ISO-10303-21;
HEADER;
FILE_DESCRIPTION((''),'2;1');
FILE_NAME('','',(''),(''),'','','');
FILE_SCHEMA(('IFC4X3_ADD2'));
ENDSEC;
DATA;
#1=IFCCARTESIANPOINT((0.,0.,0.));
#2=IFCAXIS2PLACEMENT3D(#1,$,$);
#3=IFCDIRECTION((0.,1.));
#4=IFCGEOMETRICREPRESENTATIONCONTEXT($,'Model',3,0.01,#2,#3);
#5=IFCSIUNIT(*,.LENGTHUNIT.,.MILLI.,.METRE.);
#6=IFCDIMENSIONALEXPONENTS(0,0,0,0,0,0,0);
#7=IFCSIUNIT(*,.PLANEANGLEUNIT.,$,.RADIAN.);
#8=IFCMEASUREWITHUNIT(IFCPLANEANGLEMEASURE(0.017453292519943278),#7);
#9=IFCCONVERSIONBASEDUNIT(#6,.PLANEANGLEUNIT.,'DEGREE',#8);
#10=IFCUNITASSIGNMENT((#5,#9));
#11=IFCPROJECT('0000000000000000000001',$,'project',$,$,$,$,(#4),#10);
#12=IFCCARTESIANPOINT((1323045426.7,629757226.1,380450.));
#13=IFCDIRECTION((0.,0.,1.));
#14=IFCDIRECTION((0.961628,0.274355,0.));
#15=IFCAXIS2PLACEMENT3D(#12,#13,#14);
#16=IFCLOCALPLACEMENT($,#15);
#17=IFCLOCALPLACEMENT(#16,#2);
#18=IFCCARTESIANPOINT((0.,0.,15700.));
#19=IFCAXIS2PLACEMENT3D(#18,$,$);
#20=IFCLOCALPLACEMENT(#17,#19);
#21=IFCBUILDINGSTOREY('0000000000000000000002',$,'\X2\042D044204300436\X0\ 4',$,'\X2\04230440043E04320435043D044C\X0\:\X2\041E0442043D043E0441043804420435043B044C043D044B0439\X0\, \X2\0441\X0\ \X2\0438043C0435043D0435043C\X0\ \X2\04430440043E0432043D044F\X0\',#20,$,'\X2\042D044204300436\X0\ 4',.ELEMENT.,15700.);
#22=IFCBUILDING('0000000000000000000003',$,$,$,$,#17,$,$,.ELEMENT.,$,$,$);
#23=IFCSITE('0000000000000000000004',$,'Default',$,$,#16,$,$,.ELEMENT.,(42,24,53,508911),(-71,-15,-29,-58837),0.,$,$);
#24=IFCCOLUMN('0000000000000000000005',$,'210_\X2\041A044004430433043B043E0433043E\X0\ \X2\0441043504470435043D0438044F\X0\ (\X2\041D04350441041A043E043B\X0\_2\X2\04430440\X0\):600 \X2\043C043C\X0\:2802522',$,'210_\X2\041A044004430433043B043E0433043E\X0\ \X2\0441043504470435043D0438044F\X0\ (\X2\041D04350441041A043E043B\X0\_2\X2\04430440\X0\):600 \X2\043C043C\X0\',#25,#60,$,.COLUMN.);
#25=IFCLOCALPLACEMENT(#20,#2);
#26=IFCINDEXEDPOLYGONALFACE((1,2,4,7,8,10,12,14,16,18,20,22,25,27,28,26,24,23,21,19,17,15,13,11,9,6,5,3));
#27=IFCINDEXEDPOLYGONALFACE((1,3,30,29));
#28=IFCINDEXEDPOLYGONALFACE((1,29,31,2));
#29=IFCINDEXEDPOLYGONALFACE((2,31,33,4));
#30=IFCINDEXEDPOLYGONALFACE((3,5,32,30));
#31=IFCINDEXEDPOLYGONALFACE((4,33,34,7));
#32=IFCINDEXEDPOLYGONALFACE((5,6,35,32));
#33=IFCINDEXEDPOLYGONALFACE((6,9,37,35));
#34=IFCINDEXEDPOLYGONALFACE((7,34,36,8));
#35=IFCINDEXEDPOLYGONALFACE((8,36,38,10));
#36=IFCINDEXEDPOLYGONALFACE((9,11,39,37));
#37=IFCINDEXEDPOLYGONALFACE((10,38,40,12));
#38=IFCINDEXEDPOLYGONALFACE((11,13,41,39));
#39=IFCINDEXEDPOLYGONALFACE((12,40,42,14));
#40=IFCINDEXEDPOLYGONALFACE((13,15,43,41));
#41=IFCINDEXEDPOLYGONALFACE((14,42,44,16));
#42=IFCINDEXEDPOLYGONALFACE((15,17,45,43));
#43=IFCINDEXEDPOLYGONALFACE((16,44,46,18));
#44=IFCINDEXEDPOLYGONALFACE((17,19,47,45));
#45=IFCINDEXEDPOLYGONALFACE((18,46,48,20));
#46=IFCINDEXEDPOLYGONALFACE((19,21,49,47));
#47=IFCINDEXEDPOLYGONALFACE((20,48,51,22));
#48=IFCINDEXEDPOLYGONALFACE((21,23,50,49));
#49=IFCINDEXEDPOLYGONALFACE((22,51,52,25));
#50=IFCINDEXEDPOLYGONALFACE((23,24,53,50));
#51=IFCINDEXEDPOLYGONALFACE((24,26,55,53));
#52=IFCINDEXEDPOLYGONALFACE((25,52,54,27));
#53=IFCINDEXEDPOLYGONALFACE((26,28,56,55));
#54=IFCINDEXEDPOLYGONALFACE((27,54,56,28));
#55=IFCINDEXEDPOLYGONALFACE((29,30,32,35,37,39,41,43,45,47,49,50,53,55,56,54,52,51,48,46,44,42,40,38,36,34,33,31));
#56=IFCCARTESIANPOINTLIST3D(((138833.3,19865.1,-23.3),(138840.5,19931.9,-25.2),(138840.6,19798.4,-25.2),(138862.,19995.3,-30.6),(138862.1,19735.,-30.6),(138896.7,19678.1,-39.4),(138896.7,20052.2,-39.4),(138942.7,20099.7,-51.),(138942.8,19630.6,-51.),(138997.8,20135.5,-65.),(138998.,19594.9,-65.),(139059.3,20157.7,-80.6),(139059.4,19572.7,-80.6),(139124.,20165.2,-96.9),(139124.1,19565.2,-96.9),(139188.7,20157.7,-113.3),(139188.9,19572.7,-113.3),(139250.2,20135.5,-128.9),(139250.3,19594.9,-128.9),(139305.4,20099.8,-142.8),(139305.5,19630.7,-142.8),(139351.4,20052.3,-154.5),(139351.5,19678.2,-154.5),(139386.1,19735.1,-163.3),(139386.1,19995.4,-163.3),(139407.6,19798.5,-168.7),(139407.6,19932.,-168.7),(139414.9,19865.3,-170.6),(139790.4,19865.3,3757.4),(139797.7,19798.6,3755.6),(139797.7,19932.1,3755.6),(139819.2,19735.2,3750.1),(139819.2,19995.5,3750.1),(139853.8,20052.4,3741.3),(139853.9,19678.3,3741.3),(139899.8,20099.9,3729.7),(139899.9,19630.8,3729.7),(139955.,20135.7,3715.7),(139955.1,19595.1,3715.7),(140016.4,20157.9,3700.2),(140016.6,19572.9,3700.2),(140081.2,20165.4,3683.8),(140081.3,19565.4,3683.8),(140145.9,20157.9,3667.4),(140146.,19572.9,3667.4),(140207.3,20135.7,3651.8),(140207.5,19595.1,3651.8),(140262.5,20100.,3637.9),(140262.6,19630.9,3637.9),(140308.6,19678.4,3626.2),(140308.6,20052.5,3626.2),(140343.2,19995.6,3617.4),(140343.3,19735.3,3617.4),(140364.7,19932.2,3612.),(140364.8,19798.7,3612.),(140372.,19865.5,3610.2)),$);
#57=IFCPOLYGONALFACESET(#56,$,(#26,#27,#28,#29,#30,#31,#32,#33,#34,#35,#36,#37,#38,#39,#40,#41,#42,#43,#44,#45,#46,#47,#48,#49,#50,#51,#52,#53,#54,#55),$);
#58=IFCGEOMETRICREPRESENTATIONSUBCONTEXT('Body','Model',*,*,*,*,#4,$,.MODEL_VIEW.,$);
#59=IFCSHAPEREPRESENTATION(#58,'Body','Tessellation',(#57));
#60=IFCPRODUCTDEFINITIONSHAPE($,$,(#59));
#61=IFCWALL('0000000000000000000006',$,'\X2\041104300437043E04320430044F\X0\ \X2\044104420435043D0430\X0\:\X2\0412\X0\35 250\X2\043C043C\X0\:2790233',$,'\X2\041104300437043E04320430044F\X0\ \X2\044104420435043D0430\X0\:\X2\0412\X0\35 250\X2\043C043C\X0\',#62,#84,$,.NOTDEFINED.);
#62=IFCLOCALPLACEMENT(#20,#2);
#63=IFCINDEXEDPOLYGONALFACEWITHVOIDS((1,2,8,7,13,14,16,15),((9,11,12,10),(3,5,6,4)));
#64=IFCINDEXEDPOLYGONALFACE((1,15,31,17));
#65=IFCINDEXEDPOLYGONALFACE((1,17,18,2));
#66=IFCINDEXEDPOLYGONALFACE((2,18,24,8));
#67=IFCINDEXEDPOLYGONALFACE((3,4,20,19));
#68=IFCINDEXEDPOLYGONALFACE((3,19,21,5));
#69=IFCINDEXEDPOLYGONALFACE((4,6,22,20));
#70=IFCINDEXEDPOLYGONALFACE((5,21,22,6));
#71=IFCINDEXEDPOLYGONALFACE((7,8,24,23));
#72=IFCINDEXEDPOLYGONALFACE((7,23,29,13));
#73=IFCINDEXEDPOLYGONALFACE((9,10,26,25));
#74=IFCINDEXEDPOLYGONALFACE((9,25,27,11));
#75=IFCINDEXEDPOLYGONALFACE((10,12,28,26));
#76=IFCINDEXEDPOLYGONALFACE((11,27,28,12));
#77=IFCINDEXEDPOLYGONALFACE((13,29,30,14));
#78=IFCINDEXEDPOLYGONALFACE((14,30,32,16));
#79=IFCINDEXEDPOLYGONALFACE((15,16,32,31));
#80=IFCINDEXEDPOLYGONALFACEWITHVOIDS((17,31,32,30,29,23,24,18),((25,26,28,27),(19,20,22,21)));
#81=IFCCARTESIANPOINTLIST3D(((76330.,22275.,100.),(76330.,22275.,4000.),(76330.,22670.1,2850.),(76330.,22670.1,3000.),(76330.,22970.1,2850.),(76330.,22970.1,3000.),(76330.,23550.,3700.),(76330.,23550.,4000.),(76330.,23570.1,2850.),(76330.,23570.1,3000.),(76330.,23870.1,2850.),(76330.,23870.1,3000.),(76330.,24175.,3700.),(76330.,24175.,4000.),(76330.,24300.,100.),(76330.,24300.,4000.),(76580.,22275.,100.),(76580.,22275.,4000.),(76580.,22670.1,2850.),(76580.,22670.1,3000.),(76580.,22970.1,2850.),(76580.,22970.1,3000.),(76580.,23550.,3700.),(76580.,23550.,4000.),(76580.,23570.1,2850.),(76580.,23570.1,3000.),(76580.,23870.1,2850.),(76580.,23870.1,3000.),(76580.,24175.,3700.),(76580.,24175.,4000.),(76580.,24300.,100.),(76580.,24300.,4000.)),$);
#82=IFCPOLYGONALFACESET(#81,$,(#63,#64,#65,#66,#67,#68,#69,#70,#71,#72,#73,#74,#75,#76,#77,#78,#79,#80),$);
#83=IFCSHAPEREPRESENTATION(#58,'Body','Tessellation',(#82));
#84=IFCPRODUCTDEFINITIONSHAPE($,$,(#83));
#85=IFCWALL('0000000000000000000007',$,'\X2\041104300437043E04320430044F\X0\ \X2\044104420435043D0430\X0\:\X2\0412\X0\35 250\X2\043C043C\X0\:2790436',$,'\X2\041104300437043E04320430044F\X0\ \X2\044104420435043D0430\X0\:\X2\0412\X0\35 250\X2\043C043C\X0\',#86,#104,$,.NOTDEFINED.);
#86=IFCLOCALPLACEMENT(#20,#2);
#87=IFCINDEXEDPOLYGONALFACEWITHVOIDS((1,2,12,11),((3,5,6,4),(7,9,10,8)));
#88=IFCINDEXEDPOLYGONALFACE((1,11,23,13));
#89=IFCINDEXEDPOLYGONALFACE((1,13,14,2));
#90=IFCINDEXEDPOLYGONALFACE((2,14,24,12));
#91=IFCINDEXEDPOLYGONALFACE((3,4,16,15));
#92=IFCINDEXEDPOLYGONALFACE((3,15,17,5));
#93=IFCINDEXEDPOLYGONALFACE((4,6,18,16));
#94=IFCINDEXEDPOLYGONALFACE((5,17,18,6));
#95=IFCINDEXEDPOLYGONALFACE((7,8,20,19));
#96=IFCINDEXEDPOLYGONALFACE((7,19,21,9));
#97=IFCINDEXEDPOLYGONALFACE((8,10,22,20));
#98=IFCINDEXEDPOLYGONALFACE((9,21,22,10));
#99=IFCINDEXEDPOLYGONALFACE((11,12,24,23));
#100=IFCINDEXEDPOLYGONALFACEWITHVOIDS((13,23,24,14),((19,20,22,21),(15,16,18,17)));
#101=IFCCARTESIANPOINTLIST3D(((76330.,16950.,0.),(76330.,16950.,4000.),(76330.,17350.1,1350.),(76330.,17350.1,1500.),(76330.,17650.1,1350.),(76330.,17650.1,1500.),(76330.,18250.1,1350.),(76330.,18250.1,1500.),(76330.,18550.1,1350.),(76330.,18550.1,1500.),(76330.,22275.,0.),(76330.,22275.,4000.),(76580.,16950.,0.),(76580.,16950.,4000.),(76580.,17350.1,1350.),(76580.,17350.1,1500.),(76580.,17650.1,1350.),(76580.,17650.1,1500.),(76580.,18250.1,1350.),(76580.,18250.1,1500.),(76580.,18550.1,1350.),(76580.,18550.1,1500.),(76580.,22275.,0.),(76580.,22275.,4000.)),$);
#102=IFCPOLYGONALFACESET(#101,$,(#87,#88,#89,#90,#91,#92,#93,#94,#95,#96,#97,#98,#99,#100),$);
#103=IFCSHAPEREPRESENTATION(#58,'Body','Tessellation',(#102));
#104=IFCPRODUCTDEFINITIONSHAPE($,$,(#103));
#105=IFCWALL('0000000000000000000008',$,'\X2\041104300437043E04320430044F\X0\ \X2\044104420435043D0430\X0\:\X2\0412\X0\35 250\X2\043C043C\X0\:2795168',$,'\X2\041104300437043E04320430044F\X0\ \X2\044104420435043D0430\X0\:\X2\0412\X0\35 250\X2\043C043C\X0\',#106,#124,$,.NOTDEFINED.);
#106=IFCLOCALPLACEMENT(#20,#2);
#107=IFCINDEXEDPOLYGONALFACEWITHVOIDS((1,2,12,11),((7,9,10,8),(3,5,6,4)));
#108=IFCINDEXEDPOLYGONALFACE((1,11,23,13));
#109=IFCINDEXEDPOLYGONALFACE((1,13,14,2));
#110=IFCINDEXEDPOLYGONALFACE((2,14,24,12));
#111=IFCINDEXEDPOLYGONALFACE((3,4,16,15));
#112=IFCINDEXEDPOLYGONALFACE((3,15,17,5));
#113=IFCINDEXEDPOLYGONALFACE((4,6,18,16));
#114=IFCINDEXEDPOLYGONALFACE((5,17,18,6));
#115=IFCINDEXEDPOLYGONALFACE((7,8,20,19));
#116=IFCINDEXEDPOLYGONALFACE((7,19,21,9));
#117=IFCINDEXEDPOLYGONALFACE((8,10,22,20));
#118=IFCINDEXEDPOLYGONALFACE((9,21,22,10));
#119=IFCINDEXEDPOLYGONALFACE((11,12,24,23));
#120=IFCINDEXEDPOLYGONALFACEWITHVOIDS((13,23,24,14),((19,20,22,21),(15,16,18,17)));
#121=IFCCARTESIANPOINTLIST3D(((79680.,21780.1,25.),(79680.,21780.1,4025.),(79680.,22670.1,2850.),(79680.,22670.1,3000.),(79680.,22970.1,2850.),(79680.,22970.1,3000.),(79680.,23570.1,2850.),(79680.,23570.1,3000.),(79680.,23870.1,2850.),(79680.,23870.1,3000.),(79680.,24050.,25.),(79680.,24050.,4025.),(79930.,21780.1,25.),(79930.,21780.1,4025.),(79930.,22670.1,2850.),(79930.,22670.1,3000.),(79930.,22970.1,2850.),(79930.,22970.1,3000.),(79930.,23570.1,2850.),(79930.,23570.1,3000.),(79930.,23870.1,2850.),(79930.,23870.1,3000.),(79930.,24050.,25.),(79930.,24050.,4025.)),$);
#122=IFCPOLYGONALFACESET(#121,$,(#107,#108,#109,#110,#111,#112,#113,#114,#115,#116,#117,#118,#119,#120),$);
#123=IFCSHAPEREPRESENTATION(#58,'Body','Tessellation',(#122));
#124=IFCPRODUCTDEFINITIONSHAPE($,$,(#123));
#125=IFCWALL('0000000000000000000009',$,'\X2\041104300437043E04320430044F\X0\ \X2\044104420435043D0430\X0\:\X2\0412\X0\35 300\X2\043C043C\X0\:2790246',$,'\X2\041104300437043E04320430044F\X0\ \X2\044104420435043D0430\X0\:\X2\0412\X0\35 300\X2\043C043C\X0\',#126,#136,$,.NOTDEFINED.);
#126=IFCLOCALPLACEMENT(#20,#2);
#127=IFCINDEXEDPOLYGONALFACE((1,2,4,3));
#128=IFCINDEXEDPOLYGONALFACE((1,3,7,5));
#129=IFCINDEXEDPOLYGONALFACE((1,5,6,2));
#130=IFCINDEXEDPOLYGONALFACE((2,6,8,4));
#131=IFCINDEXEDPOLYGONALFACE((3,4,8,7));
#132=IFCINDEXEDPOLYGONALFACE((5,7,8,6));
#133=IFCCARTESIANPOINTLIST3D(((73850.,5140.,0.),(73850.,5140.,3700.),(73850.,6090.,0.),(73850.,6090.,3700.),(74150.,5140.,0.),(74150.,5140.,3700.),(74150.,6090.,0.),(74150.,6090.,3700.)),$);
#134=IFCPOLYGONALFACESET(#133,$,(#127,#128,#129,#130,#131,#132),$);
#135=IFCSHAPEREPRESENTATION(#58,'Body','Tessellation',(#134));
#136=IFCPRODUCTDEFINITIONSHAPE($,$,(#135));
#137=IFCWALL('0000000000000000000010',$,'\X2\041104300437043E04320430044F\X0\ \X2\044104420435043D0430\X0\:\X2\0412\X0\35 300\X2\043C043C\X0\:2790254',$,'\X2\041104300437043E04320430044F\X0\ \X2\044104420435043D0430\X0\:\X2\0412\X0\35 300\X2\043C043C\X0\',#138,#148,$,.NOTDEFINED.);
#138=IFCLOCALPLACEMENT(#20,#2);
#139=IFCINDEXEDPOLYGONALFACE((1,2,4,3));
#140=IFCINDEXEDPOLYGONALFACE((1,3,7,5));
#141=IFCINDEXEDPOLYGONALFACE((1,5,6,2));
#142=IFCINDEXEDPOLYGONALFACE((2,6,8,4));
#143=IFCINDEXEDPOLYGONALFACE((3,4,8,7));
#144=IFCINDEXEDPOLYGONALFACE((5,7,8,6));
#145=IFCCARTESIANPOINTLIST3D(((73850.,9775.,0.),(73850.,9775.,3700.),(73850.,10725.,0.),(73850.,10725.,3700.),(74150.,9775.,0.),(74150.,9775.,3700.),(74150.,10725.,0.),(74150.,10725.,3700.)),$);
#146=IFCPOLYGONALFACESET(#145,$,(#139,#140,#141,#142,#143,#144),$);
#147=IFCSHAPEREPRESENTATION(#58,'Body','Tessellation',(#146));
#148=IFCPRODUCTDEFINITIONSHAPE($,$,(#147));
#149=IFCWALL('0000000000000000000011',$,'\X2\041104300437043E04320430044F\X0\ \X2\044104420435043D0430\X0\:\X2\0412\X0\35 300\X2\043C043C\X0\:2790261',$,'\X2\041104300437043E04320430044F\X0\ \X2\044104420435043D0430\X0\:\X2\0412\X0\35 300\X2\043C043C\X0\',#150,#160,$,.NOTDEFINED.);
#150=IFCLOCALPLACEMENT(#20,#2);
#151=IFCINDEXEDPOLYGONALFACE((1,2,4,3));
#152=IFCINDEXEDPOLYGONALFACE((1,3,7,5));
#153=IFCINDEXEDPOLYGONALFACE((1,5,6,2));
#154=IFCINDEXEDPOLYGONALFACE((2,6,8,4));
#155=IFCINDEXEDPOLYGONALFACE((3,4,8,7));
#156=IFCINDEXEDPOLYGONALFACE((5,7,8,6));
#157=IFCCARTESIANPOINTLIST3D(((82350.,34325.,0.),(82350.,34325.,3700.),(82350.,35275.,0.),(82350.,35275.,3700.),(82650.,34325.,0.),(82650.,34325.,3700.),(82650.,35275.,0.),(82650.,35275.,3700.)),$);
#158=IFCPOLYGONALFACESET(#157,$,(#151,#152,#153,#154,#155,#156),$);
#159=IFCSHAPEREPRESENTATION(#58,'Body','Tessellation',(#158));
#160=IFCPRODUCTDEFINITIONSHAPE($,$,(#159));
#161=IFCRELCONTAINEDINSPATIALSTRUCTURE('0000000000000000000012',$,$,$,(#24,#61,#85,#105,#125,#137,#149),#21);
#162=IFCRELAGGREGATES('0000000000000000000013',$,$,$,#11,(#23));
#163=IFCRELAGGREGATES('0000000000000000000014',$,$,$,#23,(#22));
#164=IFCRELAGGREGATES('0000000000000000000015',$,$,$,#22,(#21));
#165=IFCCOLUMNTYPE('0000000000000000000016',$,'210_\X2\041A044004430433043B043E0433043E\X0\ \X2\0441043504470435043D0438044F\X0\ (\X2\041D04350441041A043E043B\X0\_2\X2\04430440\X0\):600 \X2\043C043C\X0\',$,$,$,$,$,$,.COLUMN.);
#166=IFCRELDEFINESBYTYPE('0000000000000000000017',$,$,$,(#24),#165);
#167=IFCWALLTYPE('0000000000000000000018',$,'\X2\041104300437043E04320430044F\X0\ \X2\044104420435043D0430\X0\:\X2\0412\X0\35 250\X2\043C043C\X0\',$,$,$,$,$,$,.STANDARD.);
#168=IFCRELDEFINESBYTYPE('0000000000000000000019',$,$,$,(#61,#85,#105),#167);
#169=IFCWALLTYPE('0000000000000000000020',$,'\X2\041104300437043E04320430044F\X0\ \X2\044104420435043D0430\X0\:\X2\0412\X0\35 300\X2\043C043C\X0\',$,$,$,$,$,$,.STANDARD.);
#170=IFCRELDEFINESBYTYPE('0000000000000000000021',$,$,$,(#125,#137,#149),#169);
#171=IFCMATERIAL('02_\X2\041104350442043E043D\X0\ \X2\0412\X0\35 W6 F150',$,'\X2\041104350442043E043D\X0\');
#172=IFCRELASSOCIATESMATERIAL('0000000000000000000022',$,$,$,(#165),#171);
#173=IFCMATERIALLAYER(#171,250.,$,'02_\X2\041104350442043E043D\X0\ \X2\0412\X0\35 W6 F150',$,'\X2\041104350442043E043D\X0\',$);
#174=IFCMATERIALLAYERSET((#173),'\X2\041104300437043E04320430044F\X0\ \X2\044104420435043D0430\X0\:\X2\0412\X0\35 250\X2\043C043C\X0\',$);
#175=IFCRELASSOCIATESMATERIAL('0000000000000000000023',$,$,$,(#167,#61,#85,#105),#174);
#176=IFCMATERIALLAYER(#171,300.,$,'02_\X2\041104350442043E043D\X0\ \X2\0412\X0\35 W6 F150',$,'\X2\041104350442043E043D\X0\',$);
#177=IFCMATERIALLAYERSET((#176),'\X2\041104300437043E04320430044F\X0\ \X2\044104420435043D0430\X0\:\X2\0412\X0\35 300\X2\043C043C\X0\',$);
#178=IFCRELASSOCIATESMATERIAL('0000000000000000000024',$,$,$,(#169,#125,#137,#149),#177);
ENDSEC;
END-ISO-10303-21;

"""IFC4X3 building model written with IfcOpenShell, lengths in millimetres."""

from ifc_helpers import new_model, entity, si_unit, converted_unit, direction, frame, frame_2d, origin, origin_2d_with_axis, place, context, subcontext, project, spatial, rectangle, circle, extrude, source, transform, mapped, material, layer, layer_set, material_profile, profile_set, type_object, type_shapes, element, save


model = new_model("IFC4X3")

# Units and contexts
model_context = context("Model", 3, precision=0.01, world=origin(), true_north=direction((0.0, 1.0)))
body_context = subcontext(model_context, "Body", "Model", "MODEL_VIEW")
ifc_project = project(units=[si_unit("LENGTHUNIT", "METRE", prefix="MILLI"), converted_unit("PLANEANGLEUNIT", "DEGREE", entity("IfcPlaneAngleMeasure", 0.017453292519943278), si_unit("PLANEANGLEUNIT", "RADIAN"), dimensions=[0, 0, 0, 0, 0, 0, 0])], contexts=[model_context])

# Site, building, storey
site_placement = place(None, frame((1323045426.7, 629757226.1, 380450.0), z_axis=(0.0, 0.0, 1.0), x_axis=(0.961628, 0.274355, 0.0)))
site = spatial("IfcSite", under=ifc_project, at=site_placement, Name="Default", CompositionType="ELEMENT", RefLatitude=(42, 24, 53, 508911), RefLongitude=(-71, -15, -29, -58837), RefElevation=0.0)
building_placement = place(site_placement, origin())
building = spatial("IfcBuilding", under=site, at=building_placement, CompositionType="ELEMENT")
storey_placement = place(building_placement, frame((0.0, 0.0, 15700.0)))
storey = spatial("IfcBuildingStorey", under=building, at=storey_placement, Name="Этаж 4", ObjectType="Уровень:Относительный, с именем уровня", LongName="Этаж 4", CompositionType="ELEMENT", Elevation=15700.0)

# Column
ifc_material = material(Name="02_Бетон В35 W6 F150", Category="Бетон")
ifc_material_profile = material_profile(ifc_material, circle(Radius=300.0, at=origin_2d_with_axis()), Name="600 мм")
ifc_profile_set = profile_set([ifc_material_profile], Name="600 мм")
column_type_1 = type_object("IfcColumnType", Name="210_Круглого сечения (НесКол_2ур):600 мм", PredefinedType="COLUMN", material=ifc_profile_set)
shared_shape_1 = source(origin(), body_context, "Body", "SweptSolid", [
    extrude(circle(Radius=300.0, at=frame_2d((0.0, 0.0), x_axis=(1.0, 0.0))), frame((139124.1, 19865.2, 15603.1), z_axis=(0.245422, 0.000054, 0.969416), x_axis=(0.000219, -1.0, 0.0)), (0.0, 0.0, 1.0), 3900.0),
])
type_shapes(column_type_1, [shared_shape_1])
column_1_placement = place(storey_placement, frame((0.0, 0.0, -15700.0)))
element("IfcColumn", 1, at=column_1_placement, inside=storey, type_object=column_type_1, Name="210_Круглого сечения (НесКол_2ур):600 мм:2802522", ObjectType="210_Круглого сечения (НесКол_2ур):600 мм", PredefinedType="COLUMN", context=body_context, shape_type="MappedRepresentation", body=[
    mapped(shared_shape_1, transform((0.0, 0.0, 0.0), scale=1.0)),
])

# Walls, openings
ifc_layer_1 = layer(ifc_material, 250.0, Name="02_Бетон В35 W6 F150", Category="Бетон")
ifc_layer_set_1 = layer_set([ifc_layer_1], Name="Базовая стена:В35 250мм")
wall_type_1 = type_object("IfcWallType", Name="Базовая стена:В35 250мм", PredefinedType="STANDARD", material=ifc_layer_set_1)
wall_1_placement = place(storey_placement, frame((76455.0, 24300.0, 100.0), z_axis=(0.0, 0.0, 1.0), x_axis=(0.0, -1.0, 0.0)))
wall_1 = element("IfcWall", 2, at=wall_1_placement, inside=storey, type_object=wall_type_1, material=ifc_layer_set_1, Name="Базовая стена:В35 250мм:2790233", ObjectType="Базовая стена:В35 250мм", PredefinedType="NOTDEFINED", context=body_context, shape_type="SweptSolid", body=[
    extrude(rectangle(XDim=2025.0, YDim=250.0, at=frame_2d((1012.5, 0.0), x_axis=(-1.0, 0.0))), origin(), (0.0, 0.0, 1.0), 3900.0),
])
opening_1_placement = place(wall_1_placement, origin())
element("IfcOpeningElement", 3, at=opening_1_placement, cuts=wall_1, PredefinedType="OPENING", context=body_context, shape_type="SweptSolid", body=[
    extrude(rectangle(XDim=300.0, YDim=625.0, at=frame_2d((0.0, 0.0), x_axis=(0.0, 1.0))), frame((437.5, 125.0, 3750.0), z_axis=(0.0, -1.0, 0.0), x_axis=(-1.0, 0.0, 0.0)), (0.0, 0.0, 1.0), 250.0),
])
opening_2_placement = place(wall_1_placement, frame((24300.0, -76455.0, 2750.0), z_axis=(0.0, 0.0, 1.0), x_axis=(0.0, 1.0, 0.0)))
element("IfcOpeningElement", 4, at=opening_2_placement, cuts=wall_1, PredefinedType="OPENING", context=body_context, shape_type="SweptSolid", body=[
    extrude(rectangle(XDim=150.0, YDim=300.0, at=frame_2d((0.0, 0.0), x_axis=(0.0, 1.0))), frame((74806.0, 23720.1, 75.0), z_axis=(1.0, 0.0, 0.0), x_axis=(0.0, -1.0, 0.0)), (0.0, 0.0, 1.0), 3048.0),
])
opening_3_placement = place(wall_1_placement, frame((24300.0, -76455.0, 2750.0), z_axis=(0.0, 0.0, 1.0), x_axis=(0.0, 1.0, 0.0)))
element("IfcOpeningElement", 5, at=opening_3_placement, cuts=wall_1, PredefinedType="OPENING", context=body_context, shape_type="SweptSolid", body=[
    extrude(rectangle(XDim=150.0, YDim=300.0, at=frame_2d((0.0, 0.0), x_axis=(0.0, 1.0))), frame((74806.0, 22820.1, 75.0), z_axis=(1.0, 0.0, 0.0), x_axis=(0.0, -1.0, 0.0)), (0.0, 0.0, 1.0), 3048.0),
])
wall_2_placement = place(storey_placement, frame((76455.0, 22275.0, 0.0), z_axis=(0.0, 0.0, 1.0), x_axis=(0.0, -1.0, 0.0)))
wall_2 = element("IfcWall", 6, at=wall_2_placement, inside=storey, type_object=wall_type_1, material=ifc_layer_set_1, Name="Базовая стена:В35 250мм:2790436", ObjectType="Базовая стена:В35 250мм", PredefinedType="NOTDEFINED", context=body_context, shape_type="SweptSolid", body=[
    extrude(rectangle(XDim=5325.0, YDim=250.0, at=frame_2d((2662.5, 0.0), x_axis=(-1.0, 0.0))), origin(), (0.0, 0.0, 1.0), 4000.0),
])
opening_4_placement = place(wall_2_placement, frame((22275.0, -76455.0, 1350.0), z_axis=(0.0, 0.0, 1.0), x_axis=(0.0, 1.0, 0.0)))
element("IfcOpeningElement", 7, at=opening_4_placement, cuts=wall_2, PredefinedType="OPENING", context=body_context, shape_type="SweptSolid", body=[
    extrude(rectangle(XDim=150.0, YDim=300.0, at=frame_2d((0.0, 0.0), x_axis=(0.0, 1.0))), frame((74806.0, 18400.1, 75.0), z_axis=(1.0, 0.0, 0.0), x_axis=(0.0, -1.0, 0.0)), (0.0, 0.0, 1.0), 3048.0),
])
opening_5_placement = place(wall_2_placement, frame((22275.0, -76455.0, 1350.0), z_axis=(0.0, 0.0, 1.0), x_axis=(0.0, 1.0, 0.0)))
element("IfcOpeningElement", 8, at=opening_5_placement, cuts=wall_2, PredefinedType="OPENING", context=body_context, shape_type="SweptSolid", body=[
    extrude(rectangle(XDim=150.0, YDim=300.0, at=frame_2d((0.0, 0.0), x_axis=(0.0, 1.0))), frame((74806.0, 17500.1, 75.0), z_axis=(1.0, 0.0, 0.0), x_axis=(0.0, -1.0, 0.0)), (0.0, 0.0, 1.0), 3048.0),
])
wall_3_placement = place(storey_placement, frame((79805.0, 24050.0, 25.0), z_axis=(0.0, 0.0, 1.0), x_axis=(0.0, -1.0, 0.0)))
wall_3 = element("IfcWall", 9, at=wall_3_placement, inside=storey, type_object=wall_type_1, material=ifc_layer_set_1, Name="Базовая стена:В35 250мм:2795168", ObjectType="Базовая стена:В35 250мм", PredefinedType="NOTDEFINED", context=body_context, shape_type="SweptSolid", body=[
    extrude(rectangle(XDim=2269.9, YDim=250.0, at=frame_2d((1134.9, 0.0), x_axis=(-1.0, 0.0))), origin(), (0.0, 0.0, 1.0), 4000.0),
])
opening_6_placement = place(wall_3_placement, frame((24050.0, -79805.0, 2825.0), z_axis=(0.0, 0.0, 1.0), x_axis=(0.0, 1.0, 0.0)))
element("IfcOpeningElement", 10, at=opening_6_placement, cuts=wall_3, PredefinedType="OPENING", context=body_context, shape_type="SweptSolid", body=[
    extrude(rectangle(XDim=150.0, YDim=300.0, at=frame_2d((0.0, 0.0), x_axis=(0.0, 1.0))), frame((78156.0, 23720.1, 75.0), z_axis=(1.0, 0.0, 0.0), x_axis=(0.0, -1.0, 0.0)), (0.0, 0.0, 1.0), 3048.0),
])
opening_7_placement = place(wall_3_placement, frame((24050.0, -79805.0, 2825.0), z_axis=(0.0, 0.0, 1.0), x_axis=(0.0, 1.0, 0.0)))
element("IfcOpeningElement", 11, at=opening_7_placement, cuts=wall_3, PredefinedType="OPENING", context=body_context, shape_type="SweptSolid", body=[
    extrude(rectangle(XDim=150.0, YDim=300.0, at=frame_2d((0.0, 0.0), x_axis=(0.0, 1.0))), frame((78156.0, 22820.1, 75.0), z_axis=(1.0, 0.0, 0.0), x_axis=(0.0, -1.0, 0.0)), (0.0, 0.0, 1.0), 3048.0),
])

# Walls
ifc_layer_2 = layer(ifc_material, 300.0, Name="02_Бетон В35 W6 F150", Category="Бетон")
ifc_layer_set_2 = layer_set([ifc_layer_2], Name="Базовая стена:В35 300мм")
wall_type_2 = type_object("IfcWallType", Name="Базовая стена:В35 300мм", PredefinedType="STANDARD", material=ifc_layer_set_2)
for number, where, z_axis, x_axis, name in (
    (12, (74000.0, 5140.0, 0.0), (0.0, 0.0, 1.0), (0.0, 1.0, 0.0), "Базовая стена:В35 300мм:2790246"),
    (13, (74000.0, 9775.0, 0.0), (0.0, 0.0, 1.0), (0.0, 1.0, 0.0), "Базовая стена:В35 300мм:2790254"),
    (14, (82500.0, 34325.0, 0.0), (0.0, 0.0, 1.0), (0.0, 1.0, 0.0), "Базовая стена:В35 300мм:2790261"),
):
    element("IfcWall", number, at=place(storey_placement, frame(where, z_axis=z_axis, x_axis=x_axis)), inside=storey, type_object=wall_type_2, material=ifc_layer_set_2, Name=name, ObjectType="Базовая стена:В35 300мм", PredefinedType="NOTDEFINED", context=body_context, shape_type="SweptSolid", body=[
        extrude(rectangle(XDim=950.0, YDim=300.0, at=frame_2d((475.0, 0.0), x_axis=(-1.0, 0.0))), origin(), (0.0, 0.0, 1.0), 3700.0),
    ])

save(model, "model.ifc")
